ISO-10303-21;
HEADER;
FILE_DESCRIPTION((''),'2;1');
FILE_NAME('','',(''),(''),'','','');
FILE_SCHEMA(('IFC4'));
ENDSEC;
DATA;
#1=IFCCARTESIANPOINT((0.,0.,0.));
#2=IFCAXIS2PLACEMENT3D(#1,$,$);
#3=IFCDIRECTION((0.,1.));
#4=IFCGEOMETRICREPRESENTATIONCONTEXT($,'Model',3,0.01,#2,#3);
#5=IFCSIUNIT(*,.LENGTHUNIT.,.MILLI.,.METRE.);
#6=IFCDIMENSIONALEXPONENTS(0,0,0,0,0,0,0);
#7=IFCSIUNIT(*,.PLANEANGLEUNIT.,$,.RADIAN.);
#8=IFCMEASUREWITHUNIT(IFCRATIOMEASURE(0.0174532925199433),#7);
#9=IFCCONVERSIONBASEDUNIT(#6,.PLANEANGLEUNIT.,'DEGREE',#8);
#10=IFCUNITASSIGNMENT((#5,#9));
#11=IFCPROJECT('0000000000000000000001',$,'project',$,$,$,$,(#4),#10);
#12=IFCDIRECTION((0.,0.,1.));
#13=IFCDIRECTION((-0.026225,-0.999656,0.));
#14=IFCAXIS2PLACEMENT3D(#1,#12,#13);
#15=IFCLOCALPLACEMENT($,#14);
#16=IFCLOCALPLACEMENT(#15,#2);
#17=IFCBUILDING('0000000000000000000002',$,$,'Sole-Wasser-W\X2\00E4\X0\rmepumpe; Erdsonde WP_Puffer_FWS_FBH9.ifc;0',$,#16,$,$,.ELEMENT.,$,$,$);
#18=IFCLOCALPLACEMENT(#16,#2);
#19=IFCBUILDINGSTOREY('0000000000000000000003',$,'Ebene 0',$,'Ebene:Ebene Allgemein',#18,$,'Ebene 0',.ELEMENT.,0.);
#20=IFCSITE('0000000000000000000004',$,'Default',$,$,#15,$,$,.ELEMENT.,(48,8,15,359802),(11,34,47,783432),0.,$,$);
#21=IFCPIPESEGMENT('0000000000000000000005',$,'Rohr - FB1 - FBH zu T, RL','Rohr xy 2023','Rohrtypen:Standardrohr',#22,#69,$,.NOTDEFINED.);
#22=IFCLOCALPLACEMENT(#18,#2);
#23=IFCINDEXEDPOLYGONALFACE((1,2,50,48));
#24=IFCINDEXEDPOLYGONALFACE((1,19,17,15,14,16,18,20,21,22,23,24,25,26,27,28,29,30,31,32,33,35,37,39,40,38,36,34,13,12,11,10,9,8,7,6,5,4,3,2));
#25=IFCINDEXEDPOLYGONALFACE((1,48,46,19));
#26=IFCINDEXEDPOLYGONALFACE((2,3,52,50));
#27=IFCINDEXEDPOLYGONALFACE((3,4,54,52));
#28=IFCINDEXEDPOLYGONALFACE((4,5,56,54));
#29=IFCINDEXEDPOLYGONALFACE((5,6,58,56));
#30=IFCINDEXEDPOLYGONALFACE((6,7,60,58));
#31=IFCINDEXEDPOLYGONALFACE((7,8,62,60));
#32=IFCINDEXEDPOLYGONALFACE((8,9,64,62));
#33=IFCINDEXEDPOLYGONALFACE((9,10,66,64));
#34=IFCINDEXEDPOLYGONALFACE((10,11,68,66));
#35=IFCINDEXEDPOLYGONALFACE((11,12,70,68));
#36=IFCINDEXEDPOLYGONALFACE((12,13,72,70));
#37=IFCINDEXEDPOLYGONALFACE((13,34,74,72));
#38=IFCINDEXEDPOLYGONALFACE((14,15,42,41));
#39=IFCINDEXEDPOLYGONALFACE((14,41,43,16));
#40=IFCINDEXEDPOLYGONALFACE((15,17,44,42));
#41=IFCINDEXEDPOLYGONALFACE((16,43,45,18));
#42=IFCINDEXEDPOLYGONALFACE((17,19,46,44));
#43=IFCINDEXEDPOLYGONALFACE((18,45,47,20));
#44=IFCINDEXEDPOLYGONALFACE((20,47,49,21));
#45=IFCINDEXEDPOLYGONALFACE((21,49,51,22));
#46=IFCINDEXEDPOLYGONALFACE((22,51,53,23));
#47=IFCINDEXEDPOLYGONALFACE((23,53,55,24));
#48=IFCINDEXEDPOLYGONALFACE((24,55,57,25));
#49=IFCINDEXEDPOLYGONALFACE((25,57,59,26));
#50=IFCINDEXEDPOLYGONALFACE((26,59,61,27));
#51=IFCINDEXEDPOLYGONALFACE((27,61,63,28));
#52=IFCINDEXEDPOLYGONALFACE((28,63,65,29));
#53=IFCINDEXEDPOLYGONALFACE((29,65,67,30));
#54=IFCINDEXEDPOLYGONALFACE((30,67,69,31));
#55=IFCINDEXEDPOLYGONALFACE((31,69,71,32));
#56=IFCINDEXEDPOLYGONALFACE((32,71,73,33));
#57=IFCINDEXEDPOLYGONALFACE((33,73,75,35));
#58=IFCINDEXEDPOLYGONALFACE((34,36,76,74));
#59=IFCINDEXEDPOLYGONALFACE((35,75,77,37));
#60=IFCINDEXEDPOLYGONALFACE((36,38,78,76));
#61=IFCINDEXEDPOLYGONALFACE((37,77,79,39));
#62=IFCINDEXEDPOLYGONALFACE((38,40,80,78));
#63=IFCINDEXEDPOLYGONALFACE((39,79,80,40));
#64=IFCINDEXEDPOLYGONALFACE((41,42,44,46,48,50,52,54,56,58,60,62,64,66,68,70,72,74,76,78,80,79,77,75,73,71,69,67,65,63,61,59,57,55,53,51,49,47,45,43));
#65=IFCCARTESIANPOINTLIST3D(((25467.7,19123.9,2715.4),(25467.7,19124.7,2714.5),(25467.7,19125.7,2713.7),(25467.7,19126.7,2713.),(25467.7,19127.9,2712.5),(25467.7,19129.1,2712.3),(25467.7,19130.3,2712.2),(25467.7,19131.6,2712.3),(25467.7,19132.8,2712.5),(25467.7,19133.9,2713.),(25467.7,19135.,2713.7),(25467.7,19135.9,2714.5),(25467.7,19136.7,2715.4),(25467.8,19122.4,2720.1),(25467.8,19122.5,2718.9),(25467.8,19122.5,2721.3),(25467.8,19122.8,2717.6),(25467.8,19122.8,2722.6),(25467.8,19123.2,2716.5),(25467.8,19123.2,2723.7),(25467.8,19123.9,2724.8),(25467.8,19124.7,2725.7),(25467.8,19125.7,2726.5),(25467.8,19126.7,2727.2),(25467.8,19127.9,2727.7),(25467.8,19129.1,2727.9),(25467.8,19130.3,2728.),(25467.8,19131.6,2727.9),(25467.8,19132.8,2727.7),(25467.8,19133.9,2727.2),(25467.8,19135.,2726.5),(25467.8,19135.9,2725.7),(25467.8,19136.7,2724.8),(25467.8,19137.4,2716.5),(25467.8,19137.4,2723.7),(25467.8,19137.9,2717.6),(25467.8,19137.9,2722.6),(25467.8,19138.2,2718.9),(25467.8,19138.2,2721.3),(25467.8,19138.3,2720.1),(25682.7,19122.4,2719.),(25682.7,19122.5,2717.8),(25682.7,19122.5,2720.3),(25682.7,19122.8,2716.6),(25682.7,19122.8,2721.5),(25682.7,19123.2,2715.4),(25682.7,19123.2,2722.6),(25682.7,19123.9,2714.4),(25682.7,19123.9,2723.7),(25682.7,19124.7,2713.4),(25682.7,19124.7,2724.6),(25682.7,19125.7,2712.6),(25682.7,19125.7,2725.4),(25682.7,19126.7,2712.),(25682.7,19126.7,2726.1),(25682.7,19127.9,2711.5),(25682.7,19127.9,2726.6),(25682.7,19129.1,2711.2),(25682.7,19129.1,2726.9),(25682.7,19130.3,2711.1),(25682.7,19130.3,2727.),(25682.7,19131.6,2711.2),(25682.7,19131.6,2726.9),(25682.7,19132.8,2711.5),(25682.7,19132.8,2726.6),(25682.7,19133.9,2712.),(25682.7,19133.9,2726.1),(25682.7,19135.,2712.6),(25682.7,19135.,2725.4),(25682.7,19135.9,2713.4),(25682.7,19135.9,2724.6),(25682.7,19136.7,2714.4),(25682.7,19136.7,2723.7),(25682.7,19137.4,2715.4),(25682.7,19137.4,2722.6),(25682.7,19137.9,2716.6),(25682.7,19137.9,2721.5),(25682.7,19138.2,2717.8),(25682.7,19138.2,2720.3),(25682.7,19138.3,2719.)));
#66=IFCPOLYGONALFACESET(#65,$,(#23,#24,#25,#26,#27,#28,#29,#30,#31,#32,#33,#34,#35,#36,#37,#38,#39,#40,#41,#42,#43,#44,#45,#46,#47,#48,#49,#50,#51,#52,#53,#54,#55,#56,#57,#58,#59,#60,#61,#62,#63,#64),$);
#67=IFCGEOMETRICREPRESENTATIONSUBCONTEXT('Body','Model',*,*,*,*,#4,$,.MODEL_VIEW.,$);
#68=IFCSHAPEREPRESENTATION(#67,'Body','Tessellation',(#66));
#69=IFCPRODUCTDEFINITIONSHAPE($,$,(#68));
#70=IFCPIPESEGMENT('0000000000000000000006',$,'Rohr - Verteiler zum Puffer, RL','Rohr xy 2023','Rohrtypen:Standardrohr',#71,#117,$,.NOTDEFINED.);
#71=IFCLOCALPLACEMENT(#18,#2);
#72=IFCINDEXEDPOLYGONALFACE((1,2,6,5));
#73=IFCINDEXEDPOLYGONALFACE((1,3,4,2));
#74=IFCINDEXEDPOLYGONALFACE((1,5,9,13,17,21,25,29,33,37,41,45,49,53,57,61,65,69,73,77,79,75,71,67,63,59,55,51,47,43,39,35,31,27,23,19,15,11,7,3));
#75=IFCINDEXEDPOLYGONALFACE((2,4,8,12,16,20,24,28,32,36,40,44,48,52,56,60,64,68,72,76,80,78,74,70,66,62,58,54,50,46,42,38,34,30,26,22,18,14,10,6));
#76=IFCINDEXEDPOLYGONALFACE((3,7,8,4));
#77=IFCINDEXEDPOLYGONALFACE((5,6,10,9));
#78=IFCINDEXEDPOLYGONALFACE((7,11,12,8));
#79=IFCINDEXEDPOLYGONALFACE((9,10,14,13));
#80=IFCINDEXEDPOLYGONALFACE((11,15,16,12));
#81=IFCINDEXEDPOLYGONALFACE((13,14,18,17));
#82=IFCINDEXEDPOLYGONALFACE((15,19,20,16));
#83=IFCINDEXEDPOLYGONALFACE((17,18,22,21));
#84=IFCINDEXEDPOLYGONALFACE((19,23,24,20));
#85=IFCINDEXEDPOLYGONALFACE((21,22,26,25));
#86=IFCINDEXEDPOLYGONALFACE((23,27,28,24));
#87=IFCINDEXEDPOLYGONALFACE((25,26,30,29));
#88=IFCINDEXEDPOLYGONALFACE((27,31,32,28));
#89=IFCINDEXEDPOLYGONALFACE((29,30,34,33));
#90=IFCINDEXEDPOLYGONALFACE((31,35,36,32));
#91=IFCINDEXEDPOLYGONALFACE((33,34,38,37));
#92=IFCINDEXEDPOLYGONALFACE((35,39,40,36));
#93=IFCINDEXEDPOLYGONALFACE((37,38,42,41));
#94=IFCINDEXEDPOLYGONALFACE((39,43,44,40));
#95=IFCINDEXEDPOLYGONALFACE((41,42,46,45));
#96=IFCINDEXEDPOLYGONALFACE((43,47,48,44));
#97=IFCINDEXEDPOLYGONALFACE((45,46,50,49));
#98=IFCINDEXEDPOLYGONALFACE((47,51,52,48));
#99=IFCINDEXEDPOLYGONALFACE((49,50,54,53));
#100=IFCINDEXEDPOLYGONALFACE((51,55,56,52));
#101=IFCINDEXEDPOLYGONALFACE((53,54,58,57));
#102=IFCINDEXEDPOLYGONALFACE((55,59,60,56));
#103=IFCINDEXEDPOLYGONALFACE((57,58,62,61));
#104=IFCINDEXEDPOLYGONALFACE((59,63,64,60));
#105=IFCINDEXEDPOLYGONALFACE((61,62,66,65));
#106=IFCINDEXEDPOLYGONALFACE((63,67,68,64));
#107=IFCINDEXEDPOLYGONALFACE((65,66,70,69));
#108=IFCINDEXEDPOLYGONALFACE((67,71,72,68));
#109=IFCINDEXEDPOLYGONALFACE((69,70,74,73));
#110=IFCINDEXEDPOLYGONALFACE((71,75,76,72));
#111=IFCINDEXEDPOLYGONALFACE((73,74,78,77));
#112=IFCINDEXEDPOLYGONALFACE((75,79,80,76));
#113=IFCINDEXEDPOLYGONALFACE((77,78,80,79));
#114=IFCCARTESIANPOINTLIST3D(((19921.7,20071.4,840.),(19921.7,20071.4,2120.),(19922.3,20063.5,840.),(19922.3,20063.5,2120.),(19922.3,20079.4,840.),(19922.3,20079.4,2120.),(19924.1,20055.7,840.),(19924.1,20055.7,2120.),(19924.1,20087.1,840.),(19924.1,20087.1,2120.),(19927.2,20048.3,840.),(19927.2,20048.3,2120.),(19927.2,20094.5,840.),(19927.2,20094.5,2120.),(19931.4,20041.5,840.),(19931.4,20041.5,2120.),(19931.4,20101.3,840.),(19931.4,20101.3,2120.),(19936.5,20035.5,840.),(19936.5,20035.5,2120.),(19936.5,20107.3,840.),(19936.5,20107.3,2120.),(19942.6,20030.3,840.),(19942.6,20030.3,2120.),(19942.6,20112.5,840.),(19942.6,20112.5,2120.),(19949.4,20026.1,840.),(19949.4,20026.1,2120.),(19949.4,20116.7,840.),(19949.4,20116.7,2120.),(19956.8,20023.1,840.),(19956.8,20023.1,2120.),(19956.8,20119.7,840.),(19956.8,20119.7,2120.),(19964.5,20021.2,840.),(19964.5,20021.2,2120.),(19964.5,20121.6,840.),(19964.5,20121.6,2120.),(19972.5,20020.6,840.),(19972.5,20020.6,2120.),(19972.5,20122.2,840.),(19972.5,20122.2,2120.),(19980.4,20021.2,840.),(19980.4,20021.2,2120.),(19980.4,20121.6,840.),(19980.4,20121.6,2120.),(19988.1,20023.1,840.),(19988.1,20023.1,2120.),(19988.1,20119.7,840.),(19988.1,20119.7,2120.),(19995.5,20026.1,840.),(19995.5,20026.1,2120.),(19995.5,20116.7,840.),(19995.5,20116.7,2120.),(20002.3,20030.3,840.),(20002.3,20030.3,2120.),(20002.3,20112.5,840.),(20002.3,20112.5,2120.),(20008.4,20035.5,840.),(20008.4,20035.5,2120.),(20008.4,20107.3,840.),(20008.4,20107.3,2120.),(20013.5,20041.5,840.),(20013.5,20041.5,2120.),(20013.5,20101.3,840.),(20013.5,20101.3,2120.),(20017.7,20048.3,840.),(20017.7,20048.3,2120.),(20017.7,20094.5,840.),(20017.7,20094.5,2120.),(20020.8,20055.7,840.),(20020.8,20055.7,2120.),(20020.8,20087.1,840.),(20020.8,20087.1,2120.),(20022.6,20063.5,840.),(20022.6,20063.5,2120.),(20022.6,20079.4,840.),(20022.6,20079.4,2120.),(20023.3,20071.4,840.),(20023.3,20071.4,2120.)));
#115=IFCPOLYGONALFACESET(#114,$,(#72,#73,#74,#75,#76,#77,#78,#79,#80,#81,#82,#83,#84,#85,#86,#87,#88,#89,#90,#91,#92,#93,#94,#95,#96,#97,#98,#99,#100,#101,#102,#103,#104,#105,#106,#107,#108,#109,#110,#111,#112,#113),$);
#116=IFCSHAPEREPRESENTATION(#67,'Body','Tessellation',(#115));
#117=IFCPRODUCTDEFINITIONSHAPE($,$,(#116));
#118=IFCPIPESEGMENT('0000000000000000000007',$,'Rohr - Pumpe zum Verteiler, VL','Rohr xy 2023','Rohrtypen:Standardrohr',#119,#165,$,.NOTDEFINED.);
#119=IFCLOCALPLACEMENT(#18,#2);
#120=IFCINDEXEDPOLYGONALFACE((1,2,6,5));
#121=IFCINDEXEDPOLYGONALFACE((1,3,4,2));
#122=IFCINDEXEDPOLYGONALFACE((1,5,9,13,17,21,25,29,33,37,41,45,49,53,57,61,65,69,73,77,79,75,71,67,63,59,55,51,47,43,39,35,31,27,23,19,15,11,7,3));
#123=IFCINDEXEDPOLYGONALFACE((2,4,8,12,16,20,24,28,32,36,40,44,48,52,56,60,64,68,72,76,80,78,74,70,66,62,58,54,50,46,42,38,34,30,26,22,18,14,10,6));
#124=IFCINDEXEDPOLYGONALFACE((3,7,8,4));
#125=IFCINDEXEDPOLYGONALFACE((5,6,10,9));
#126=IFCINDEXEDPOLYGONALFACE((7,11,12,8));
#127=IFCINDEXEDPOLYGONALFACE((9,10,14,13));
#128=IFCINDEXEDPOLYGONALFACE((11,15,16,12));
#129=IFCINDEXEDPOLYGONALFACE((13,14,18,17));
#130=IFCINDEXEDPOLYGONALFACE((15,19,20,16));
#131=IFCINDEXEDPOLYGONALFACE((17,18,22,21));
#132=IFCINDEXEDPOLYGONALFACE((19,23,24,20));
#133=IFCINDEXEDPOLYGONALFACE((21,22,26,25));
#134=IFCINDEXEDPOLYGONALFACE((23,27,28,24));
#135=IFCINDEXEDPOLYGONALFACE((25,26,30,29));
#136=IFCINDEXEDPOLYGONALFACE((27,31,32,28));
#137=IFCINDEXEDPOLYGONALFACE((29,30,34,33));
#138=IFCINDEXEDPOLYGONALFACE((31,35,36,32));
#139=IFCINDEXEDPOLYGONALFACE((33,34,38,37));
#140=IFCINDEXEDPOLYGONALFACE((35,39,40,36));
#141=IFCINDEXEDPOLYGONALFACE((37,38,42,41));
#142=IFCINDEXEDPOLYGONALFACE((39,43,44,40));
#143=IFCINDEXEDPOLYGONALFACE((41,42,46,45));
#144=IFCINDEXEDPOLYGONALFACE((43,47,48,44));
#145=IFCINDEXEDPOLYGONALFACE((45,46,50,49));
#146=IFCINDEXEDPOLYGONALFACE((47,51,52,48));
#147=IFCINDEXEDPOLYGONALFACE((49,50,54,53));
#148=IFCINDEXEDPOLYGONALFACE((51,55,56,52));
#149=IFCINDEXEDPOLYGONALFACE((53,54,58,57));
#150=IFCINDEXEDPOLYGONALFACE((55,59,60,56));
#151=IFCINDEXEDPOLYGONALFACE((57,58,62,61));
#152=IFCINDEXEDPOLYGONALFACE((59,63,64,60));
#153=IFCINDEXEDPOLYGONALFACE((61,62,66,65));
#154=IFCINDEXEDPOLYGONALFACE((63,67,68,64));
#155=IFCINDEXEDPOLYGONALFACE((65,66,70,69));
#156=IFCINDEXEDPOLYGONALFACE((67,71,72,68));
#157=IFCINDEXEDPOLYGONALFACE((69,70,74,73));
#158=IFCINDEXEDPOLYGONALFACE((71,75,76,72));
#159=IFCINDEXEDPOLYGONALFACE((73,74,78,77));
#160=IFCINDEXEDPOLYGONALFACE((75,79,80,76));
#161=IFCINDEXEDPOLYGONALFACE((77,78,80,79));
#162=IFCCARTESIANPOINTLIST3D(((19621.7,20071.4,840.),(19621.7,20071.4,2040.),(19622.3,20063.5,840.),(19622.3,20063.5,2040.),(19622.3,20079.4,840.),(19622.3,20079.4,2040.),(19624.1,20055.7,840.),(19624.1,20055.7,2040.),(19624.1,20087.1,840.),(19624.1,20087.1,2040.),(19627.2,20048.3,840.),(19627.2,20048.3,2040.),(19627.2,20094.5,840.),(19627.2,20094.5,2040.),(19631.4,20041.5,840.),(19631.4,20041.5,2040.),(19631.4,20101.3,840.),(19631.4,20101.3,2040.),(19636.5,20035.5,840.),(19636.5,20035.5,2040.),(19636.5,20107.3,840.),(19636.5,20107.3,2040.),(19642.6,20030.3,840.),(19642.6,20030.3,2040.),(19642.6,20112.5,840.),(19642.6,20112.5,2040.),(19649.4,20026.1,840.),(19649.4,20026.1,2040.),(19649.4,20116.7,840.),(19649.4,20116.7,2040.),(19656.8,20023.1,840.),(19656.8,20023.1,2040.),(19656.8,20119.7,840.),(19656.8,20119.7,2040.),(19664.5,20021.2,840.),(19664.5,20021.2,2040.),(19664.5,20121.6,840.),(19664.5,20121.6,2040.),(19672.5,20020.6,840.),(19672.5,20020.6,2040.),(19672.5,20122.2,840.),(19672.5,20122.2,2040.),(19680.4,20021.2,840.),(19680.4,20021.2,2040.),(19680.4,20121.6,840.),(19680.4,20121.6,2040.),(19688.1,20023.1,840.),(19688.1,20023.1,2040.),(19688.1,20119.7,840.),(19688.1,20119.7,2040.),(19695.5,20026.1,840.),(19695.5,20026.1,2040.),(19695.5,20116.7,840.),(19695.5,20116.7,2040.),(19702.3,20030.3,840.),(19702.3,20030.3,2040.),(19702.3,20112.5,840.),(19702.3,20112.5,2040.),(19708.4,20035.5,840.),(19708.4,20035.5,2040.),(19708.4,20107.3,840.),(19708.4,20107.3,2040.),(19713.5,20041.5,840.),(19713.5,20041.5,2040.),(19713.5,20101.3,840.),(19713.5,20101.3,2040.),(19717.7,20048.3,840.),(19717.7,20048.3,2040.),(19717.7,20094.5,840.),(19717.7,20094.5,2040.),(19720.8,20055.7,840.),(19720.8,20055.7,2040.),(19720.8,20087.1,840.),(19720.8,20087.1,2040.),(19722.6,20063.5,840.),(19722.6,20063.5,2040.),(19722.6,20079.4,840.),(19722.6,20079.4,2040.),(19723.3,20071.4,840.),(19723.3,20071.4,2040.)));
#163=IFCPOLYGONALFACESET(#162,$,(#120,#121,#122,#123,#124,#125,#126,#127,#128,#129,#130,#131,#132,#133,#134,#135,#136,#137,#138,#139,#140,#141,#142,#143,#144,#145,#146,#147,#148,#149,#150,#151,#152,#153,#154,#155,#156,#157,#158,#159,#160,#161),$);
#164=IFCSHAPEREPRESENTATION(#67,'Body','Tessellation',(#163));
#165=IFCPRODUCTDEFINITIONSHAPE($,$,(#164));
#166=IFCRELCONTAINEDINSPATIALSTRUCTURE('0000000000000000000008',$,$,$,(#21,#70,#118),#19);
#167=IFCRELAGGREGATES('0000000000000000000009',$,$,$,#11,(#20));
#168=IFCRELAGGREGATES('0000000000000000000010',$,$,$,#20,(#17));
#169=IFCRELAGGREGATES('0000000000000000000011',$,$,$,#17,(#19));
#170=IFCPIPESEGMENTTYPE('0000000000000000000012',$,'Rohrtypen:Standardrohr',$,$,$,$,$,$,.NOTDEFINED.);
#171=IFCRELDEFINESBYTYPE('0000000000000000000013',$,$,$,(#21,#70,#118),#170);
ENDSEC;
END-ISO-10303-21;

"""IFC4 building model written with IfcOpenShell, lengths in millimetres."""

from ifc_helpers import new_model, entity, si_unit, converted_unit, direction, frame, origin, place, context, subcontext, project, spatial, indexed_curve, outline, extrude, type_object, element, save


model = new_model("IFC4")

# Units and contexts
model_context = context("Model", 3, precision=0.01, world=origin(), true_north=direction((0.0, 1.0)))
body_context = subcontext(model_context, "Body", "Model", "MODEL_VIEW")
ifc_project = project(units=[si_unit("LENGTHUNIT", "METRE", prefix="MILLI"), converted_unit("PLANEANGLEUNIT", "DEGREE", entity("IfcRatioMeasure", 0.0174532925199433), si_unit("PLANEANGLEUNIT", "RADIAN"), dimensions=[0, 0, 0, 0, 0, 0, 0])], contexts=[model_context])

# Site, building, storey
site_placement = place(None, frame((0.0, 0.0, 0.0), z_axis=(0.0, 0.0, 1.0), x_axis=(-0.026225, -0.999656, 0.0)))
site = spatial("IfcSite", under=ifc_project, at=site_placement, Name="Default", CompositionType="ELEMENT", RefLatitude=(48, 8, 15, 359802), RefLongitude=(11, 34, 47, 783432), RefElevation=0.0)
building_placement = place(site_placement, origin())
building = spatial("IfcBuilding", under=site, at=building_placement, Description="Sole-Wasser-Wärmepumpe; Erdsonde WP_Puffer_FWS_FBH9.ifc;0", CompositionType="ELEMENT")
storey_placement = place(building_placement, origin())
storey = spatial("IfcBuildingStorey", under=building, at=storey_placement, Name="Ebene 0", ObjectType="Ebene:Ebene Allgemein", LongName="Ebene 0", CompositionType="ELEMENT", Elevation=0.0)

# Pipe segments
pipe_segment_type = type_object("IfcPipeSegmentType", Name="Rohrtypen:Standardrohr", PredefinedType="NOTDEFINED")
pipe_segment_1_placement = place(storey_placement, origin())
element("IfcPipeSegment", 1, at=pipe_segment_1_placement, inside=storey, type_object=pipe_segment_type, Name="Rohr - FB1 - FBH zu T, RL", Description="Rohr xy 2023", ObjectType="Rohrtypen:Standardrohr", PredefinedType="NOTDEFINED", context=body_context, shape_type="SweptSolid", body=[
    extrude(outline(indexed_curve([(7.9, 0.0), (7.8, 1.2), (7.6, 2.5), (7.1, 3.6), (6.4, 4.7), (5.6, 5.6), (4.7, 6.4), (3.6, 7.1), (2.5, 7.6), (1.2, 7.8), (0.0, 7.9), (-1.2, 7.8), (-2.5, 7.6), (-3.6, 7.1), (-4.7, 6.4), (-5.6, 5.6), (-6.4, 4.7), (-7.1, 3.6), (-7.6, 2.5), (-7.8, 1.2), (-7.9, 0.0), (-7.8, -1.2), (-7.6, -2.5), (-7.1, -3.6), (-6.4, -4.7), (-5.6, -5.6), (-4.7, -6.4), (-3.6, -7.1), (-2.5, -7.6), (-1.2, -7.8), (0.0, -7.9), (1.2, -7.8), (2.5, -7.6), (3.6, -7.1), (4.7, -6.4), (5.6, -5.6), (6.4, -4.7), (7.1, -3.6), (7.6, -2.5), (7.8, -1.2), (7.9, 0.0)], self_intersect=False)), frame((25682.7, 19130.3, 2719.0), z_axis=(-0.999988, 0.0, 0.005), x_axis=(0.0, 1.0, 0.0)), (0.0, 0.0, 1.0), 214.9),
])
pipe_segment_2_placement = place(storey_placement, origin())
element("IfcPipeSegment", 2, at=pipe_segment_2_placement, inside=storey, type_object=pipe_segment_type, Name="Rohr - Verteiler zum Puffer, RL", Description="Rohr xy 2023", ObjectType="Rohrtypen:Standardrohr", PredefinedType="NOTDEFINED", context=body_context, shape_type="SweptSolid", body=[
    extrude(outline(indexed_curve([(50.8, 0.0), (50.2, 7.9), (48.3, 15.7), (45.3, 23.1), (41.1, 29.9), (35.9, 35.9), (29.9, 41.1), (23.1, 45.3), (15.7, 48.3), (7.9, 50.2), (0.0, 50.8), (-7.9, 50.2), (-15.7, 48.3), (-23.1, 45.3), (-29.9, 41.1), (-35.9, 35.9), (-41.1, 29.9), (-45.3, 23.1), (-48.3, 15.7), (-50.2, 7.9), (-50.8, 0.0), (-50.2, -7.9), (-48.3, -15.7), (-45.3, -23.1), (-41.1, -29.9), (-35.9, -35.9), (-29.9, -41.1), (-23.1, -45.3), (-15.7, -48.3), (-7.9, -50.2), (0.0, -50.8), (7.9, -50.2), (15.7, -48.3), (23.1, -45.3), (29.9, -41.1), (35.9, -35.9), (41.1, -29.9), (45.3, -23.1), (48.3, -15.7), (50.2, -7.9), (50.8, 0.0)], self_intersect=False)), frame((19972.5, 20071.4, 840.0), z_axis=(0.0, 0.0, 1.0), x_axis=(-1.0, 0.0, 0.0)), (0.0, 0.0, 1.0), 1280.0),
])
pipe_segment_3_placement = place(storey_placement, origin())
element("IfcPipeSegment", 3, at=pipe_segment_3_placement, inside=storey, type_object=pipe_segment_type, Name="Rohr - Pumpe zum Verteiler, VL", Description="Rohr xy 2023", ObjectType="Rohrtypen:Standardrohr", PredefinedType="NOTDEFINED", context=body_context, shape_type="SweptSolid", body=[
    extrude(outline(indexed_curve([(50.8, 0.0), (50.2, 7.9), (48.3, 15.7), (45.3, 23.1), (41.1, 29.9), (35.9, 35.9), (29.9, 41.1), (23.1, 45.3), (15.7, 48.3), (7.9, 50.2), (0.0, 50.8), (-7.9, 50.2), (-15.7, 48.3), (-23.1, 45.3), (-29.9, 41.1), (-35.9, 35.9), (-41.1, 29.9), (-45.3, 23.1), (-48.3, 15.7), (-50.2, 7.9), (-50.8, 0.0), (-50.2, -7.9), (-48.3, -15.7), (-45.3, -23.1), (-41.1, -29.9), (-35.9, -35.9), (-29.9, -41.1), (-23.1, -45.3), (-15.7, -48.3), (-7.9, -50.2), (0.0, -50.8), (7.9, -50.2), (15.7, -48.3), (23.1, -45.3), (29.9, -41.1), (35.9, -35.9), (41.1, -29.9), (45.3, -23.1), (48.3, -15.7), (50.2, -7.9), (50.8, 0.0)], self_intersect=False)), frame((19672.5, 20071.4, 840.0), z_axis=(0.0, 0.0, 1.0), x_axis=(-1.0, 0.0, 0.0)), (0.0, 0.0, 1.0), 1200.0),
])

save(model, "model.ifc")
